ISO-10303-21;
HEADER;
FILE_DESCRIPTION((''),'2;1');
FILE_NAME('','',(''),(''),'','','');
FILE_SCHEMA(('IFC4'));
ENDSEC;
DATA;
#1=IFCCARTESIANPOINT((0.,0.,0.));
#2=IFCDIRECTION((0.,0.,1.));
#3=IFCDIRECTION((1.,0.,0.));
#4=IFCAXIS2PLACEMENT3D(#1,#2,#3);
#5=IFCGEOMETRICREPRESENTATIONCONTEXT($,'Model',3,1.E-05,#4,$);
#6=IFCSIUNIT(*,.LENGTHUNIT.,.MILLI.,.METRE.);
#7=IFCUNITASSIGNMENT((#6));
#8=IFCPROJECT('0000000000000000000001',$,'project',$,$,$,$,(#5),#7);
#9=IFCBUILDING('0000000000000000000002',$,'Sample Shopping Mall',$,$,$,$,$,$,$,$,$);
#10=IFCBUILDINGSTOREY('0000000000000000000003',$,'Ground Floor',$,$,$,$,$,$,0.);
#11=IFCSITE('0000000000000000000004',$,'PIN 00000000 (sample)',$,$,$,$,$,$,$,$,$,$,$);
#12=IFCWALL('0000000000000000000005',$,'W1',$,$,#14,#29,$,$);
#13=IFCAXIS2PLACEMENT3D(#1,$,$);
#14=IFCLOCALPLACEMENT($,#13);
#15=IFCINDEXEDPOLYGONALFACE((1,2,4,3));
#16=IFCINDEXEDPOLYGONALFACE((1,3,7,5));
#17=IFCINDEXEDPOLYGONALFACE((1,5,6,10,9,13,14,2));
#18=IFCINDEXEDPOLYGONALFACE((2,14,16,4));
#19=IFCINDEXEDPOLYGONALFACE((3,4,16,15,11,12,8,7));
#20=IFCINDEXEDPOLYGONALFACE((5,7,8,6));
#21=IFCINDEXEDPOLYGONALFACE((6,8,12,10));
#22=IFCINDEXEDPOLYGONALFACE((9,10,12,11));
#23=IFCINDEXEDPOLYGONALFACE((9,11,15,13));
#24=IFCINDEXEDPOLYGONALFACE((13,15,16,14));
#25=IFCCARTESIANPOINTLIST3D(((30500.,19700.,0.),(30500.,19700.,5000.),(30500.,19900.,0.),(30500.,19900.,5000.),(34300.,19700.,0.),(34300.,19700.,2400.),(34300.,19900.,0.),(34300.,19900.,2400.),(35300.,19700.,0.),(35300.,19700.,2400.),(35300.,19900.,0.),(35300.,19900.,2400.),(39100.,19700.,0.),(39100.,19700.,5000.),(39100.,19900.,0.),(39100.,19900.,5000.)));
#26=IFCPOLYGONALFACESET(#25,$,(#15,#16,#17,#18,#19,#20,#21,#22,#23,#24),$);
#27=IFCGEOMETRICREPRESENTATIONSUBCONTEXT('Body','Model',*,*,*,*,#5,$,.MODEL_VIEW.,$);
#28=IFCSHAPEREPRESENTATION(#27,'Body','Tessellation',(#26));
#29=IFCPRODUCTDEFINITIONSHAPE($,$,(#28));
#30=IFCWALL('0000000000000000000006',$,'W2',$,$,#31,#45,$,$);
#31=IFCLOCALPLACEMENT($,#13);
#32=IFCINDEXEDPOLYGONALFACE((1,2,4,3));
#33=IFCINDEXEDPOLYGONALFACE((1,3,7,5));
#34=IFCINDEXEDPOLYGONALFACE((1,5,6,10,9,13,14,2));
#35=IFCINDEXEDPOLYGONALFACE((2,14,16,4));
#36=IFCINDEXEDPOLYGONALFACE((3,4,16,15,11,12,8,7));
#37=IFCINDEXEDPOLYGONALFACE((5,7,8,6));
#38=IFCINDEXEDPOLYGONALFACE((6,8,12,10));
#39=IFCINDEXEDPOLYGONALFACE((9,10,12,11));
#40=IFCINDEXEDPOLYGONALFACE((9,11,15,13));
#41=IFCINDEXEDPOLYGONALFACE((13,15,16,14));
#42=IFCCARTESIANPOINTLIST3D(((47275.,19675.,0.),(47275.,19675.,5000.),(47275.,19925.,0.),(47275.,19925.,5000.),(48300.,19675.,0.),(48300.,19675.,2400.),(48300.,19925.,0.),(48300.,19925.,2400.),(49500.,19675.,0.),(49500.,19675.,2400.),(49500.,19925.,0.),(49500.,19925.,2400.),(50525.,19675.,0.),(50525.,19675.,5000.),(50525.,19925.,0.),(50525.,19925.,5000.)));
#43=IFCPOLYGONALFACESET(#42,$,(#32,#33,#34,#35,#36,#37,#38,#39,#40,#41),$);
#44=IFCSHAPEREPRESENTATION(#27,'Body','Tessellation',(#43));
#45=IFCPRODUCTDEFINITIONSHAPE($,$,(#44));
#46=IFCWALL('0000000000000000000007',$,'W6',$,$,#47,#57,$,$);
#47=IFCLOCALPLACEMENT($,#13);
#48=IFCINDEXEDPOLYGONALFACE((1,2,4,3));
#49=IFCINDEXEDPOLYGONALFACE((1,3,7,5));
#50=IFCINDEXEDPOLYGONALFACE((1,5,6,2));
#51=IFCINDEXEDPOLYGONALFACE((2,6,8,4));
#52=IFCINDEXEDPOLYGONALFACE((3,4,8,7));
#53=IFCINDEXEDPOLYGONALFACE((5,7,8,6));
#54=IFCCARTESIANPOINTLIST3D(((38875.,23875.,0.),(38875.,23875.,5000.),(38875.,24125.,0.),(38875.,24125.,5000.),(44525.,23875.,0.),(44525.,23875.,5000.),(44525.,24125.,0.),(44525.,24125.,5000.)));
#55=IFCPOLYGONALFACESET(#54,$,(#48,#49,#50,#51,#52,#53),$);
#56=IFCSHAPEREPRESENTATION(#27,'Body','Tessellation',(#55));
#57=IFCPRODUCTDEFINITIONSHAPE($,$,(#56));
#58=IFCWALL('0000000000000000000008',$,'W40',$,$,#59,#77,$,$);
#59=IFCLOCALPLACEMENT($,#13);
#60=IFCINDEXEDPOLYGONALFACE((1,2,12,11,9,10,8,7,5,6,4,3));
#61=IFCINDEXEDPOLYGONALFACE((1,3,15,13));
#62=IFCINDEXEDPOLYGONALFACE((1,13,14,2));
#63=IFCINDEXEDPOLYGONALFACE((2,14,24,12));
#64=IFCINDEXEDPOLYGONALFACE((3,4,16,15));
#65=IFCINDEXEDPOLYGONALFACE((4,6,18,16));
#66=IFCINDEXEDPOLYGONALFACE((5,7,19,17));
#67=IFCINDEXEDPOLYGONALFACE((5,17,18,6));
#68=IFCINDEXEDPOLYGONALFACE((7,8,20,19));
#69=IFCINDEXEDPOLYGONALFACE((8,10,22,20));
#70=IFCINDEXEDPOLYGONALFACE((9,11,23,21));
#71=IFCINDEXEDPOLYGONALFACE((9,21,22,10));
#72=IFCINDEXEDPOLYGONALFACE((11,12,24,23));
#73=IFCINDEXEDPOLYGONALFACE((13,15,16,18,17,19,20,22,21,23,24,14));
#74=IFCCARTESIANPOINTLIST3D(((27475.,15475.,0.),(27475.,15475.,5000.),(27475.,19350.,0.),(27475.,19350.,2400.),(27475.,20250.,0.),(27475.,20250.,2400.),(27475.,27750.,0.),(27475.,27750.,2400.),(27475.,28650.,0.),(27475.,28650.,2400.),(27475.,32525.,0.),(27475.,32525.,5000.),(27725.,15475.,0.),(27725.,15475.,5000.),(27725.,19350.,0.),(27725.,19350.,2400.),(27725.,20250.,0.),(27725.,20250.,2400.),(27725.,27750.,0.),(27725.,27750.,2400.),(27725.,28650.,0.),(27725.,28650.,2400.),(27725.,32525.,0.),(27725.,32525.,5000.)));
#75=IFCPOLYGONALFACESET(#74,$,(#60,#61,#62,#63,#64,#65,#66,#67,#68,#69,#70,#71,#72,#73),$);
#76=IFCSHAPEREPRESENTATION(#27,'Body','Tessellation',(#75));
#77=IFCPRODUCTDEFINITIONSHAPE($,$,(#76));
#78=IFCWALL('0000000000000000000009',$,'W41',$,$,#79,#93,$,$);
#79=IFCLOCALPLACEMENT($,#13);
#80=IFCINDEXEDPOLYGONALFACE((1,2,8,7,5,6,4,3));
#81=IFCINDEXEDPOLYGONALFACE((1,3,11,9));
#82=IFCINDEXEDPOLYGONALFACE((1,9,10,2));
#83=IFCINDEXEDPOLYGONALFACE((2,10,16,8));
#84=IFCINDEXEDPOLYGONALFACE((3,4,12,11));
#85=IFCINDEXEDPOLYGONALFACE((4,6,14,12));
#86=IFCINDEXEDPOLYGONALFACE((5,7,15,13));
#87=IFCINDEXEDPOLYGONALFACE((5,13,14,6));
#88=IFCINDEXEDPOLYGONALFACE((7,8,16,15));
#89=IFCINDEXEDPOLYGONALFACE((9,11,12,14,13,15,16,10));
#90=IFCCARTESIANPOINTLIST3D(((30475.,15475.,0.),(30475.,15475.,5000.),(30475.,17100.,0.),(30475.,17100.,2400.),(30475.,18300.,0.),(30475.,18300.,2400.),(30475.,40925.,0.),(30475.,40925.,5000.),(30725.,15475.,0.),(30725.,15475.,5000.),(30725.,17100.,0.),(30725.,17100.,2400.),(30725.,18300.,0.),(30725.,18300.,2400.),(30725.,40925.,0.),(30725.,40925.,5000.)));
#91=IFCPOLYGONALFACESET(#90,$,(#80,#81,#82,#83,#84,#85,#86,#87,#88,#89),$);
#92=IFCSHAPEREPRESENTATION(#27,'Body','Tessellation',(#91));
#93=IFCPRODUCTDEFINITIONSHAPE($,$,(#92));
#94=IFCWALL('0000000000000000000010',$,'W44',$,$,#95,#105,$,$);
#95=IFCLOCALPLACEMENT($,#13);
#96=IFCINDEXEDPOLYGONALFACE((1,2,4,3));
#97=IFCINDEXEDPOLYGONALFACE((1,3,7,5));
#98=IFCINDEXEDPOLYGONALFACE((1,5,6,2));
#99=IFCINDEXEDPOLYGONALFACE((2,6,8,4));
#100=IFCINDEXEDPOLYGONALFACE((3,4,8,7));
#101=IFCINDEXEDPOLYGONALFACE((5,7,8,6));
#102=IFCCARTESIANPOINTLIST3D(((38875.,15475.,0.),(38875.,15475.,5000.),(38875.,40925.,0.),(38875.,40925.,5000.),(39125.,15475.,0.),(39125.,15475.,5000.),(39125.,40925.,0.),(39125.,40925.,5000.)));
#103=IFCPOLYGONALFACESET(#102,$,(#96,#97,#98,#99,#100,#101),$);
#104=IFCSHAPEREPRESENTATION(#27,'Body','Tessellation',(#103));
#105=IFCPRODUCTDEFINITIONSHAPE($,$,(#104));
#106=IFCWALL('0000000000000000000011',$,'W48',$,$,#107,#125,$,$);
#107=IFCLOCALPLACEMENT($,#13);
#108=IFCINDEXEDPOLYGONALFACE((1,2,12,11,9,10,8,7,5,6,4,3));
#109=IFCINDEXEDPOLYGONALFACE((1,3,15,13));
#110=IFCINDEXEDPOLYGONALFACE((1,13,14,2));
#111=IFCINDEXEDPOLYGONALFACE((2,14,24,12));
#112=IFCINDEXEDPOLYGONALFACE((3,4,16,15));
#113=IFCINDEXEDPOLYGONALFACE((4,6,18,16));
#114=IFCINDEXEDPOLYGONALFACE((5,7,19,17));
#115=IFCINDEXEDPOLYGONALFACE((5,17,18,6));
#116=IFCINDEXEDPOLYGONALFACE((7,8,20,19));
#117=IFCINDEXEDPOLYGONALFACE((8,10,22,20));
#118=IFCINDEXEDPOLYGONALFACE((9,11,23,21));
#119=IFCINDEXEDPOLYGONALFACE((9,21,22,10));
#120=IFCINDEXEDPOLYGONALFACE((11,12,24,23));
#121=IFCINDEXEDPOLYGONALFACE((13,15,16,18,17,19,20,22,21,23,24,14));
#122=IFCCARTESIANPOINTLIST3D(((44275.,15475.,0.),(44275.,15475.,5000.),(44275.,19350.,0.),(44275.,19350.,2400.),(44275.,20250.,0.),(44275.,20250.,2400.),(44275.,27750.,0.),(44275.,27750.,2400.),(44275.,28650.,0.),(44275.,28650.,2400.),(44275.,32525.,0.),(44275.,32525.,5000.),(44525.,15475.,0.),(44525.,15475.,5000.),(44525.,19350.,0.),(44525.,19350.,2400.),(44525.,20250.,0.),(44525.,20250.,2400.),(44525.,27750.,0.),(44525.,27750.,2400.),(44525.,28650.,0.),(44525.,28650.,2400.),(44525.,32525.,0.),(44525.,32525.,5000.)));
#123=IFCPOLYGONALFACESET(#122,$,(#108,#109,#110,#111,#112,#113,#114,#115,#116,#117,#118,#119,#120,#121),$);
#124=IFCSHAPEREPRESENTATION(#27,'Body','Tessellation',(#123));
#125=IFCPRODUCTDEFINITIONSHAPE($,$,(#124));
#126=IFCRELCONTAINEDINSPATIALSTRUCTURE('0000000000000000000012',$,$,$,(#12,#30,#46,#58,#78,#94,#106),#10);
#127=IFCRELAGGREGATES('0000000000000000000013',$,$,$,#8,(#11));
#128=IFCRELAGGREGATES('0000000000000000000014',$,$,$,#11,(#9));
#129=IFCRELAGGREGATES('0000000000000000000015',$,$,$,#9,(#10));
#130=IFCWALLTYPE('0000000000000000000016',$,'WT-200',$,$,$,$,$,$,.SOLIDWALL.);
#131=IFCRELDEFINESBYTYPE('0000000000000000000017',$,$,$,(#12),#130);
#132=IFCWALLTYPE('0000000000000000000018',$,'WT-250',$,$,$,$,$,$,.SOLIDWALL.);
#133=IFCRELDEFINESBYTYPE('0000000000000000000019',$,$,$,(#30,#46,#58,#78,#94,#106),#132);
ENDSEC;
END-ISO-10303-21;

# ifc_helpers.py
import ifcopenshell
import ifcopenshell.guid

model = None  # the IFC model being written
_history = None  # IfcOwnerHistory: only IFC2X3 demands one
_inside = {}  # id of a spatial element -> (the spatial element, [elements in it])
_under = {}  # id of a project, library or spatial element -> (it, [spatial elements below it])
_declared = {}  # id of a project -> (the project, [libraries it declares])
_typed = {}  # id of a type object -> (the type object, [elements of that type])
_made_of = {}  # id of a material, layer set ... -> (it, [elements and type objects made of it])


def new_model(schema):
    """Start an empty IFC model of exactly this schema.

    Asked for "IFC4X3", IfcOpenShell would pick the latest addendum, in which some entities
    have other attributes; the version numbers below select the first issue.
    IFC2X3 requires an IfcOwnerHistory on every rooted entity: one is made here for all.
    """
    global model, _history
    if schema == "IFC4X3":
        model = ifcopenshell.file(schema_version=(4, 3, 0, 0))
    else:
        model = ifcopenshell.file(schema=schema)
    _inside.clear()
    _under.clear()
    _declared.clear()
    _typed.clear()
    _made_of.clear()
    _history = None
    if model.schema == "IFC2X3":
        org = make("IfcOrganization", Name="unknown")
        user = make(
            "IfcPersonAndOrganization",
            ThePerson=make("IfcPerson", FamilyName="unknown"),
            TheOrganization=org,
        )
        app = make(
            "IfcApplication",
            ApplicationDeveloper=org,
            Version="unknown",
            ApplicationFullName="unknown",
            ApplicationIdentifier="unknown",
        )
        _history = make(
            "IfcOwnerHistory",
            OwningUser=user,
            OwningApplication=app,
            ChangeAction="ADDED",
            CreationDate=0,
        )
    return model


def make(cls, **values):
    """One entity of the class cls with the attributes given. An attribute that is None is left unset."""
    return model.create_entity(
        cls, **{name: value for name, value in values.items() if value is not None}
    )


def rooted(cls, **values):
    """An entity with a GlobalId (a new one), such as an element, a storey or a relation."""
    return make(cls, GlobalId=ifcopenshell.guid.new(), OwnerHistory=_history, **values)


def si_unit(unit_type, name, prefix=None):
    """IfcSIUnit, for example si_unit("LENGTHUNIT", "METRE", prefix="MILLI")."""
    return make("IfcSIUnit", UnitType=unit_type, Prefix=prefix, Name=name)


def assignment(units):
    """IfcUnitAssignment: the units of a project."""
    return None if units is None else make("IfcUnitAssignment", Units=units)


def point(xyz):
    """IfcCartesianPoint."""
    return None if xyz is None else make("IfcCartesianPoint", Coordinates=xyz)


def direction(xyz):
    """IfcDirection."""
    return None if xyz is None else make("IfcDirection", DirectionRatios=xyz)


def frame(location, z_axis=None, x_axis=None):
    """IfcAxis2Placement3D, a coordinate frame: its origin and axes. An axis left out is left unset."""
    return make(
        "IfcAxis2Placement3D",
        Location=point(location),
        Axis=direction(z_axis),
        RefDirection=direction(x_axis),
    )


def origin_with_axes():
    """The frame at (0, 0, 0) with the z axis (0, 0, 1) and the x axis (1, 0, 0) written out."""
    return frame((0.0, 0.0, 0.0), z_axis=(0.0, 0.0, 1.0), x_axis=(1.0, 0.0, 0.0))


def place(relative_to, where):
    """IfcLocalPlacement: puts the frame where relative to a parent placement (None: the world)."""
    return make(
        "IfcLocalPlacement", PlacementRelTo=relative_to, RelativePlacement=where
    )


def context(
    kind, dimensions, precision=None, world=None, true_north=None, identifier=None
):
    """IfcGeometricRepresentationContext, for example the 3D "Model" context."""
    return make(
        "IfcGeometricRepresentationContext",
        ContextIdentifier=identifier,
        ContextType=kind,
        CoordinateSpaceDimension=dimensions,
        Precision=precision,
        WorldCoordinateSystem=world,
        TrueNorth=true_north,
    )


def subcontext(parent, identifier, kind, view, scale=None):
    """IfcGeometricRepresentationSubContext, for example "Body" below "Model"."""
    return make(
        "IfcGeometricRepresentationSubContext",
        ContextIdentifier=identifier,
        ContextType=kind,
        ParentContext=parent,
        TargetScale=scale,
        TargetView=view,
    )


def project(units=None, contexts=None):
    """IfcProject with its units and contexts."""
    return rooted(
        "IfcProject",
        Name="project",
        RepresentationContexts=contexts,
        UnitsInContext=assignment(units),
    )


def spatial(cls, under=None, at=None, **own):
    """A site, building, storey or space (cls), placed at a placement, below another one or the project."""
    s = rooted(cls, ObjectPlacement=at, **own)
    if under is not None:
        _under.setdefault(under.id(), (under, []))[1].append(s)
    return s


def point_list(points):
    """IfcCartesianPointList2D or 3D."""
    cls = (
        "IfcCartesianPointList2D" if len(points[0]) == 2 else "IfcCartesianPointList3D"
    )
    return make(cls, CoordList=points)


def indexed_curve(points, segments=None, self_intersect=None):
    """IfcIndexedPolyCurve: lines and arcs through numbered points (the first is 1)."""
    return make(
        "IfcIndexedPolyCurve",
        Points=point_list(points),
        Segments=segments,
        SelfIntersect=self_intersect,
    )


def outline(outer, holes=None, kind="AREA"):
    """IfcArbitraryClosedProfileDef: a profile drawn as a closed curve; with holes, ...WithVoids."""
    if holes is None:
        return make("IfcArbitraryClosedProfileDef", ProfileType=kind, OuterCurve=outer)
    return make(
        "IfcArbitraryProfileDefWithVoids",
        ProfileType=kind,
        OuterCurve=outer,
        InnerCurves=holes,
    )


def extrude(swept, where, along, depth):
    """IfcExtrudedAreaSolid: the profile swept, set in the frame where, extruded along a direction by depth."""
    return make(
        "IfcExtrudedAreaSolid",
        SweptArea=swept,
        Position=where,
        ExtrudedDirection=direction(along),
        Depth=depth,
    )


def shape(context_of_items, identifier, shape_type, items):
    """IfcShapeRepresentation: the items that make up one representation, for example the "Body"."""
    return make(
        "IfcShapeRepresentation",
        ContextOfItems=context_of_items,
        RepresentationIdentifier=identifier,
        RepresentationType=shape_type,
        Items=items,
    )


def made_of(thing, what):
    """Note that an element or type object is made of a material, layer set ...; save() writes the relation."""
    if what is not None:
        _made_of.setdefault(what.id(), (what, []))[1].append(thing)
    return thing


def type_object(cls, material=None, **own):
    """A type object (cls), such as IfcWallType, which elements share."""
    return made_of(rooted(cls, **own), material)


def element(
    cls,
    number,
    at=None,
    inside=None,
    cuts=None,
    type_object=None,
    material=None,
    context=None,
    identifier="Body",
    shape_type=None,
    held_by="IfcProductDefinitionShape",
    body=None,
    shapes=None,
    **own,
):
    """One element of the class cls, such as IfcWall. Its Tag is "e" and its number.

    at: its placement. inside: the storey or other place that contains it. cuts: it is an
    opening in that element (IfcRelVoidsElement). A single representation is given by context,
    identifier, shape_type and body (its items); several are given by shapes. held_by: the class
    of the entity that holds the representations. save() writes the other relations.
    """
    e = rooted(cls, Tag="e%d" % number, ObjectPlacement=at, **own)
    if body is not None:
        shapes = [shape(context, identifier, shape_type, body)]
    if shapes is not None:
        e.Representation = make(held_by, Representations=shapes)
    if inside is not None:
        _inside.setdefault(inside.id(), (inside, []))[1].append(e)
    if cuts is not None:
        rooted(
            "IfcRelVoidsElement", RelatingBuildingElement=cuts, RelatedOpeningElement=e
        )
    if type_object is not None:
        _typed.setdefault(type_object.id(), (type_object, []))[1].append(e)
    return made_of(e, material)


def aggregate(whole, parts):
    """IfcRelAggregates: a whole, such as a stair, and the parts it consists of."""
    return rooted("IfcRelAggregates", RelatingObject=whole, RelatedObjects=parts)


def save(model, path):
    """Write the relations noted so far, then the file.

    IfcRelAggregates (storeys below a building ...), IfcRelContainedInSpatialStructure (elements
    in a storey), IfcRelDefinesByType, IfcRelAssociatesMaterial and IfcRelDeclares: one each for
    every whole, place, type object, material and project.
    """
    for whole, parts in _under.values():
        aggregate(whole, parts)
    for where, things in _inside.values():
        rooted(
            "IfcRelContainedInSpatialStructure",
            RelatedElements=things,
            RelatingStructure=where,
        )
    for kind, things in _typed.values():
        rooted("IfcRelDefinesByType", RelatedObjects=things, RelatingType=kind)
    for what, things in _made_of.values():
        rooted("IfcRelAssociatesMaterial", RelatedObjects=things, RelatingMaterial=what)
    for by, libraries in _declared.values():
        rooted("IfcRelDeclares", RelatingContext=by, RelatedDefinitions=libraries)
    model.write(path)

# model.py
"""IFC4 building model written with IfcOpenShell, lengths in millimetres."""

from ifc_helpers import new_model, si_unit, frame, origin_with_axes, place, context, subcontext, project, spatial, indexed_curve, outline, extrude, type_object, element, save


model = new_model("IFC4")

# Units and contexts
model_context = context("Model", 3, precision=1e-05, world=origin_with_axes())
body_context = subcontext(model_context, "Body", "Model", "MODEL_VIEW")
ifc_project = project(units=[si_unit("LENGTHUNIT", "METRE", prefix="MILLI")], contexts=[model_context])

# Site, building, storey
site = spatial("IfcSite", under=ifc_project, Name="PIN 00000000 (sample)")
building = spatial("IfcBuilding", under=site, Name="Sample Shopping Mall")
storey = spatial("IfcBuildingStorey", under=building, Name="Ground Floor", Elevation=0.0)

# Walls, openings
wall_type_1 = type_object("IfcWallType", Name="WT-200", PredefinedType="SOLIDWALL")
wall_1_placement = place(None, frame((30500.0, 19700.0, 0.0), z_axis=(0.0, 0.0, 1.0), x_axis=(1.0, 0.0, 0.0)))
wall_1 = element("IfcWall", 1, at=wall_1_placement, inside=storey, type_object=wall_type_1, Name="W1", context=body_context, shape_type="SweptSolid", body=[
    extrude(outline(indexed_curve([(0.0, 0.0), (0.0, 200.0), (8600.0, 200.0), (8600.0, 0.0), (0.0, 0.0)], self_intersect=False)), origin_with_axes(), (0.0, 0.0, 1.0), 5000.0),
])
opening_1_placement = place(wall_1_placement, frame((3800.0, -100.0, 0.0), z_axis=(0.0, 0.0, 1.0), x_axis=(1.0, 0.0, 0.0)))
element("IfcOpeningElement", 2, at=opening_1_placement, cuts=wall_1, context=body_context, shape_type="SweptSolid", body=[
    extrude(outline(indexed_curve([(0.0, 0.0), (0.0, 400.0), (1000.0, 400.0), (1000.0, 0.0), (0.0, 0.0)], self_intersect=False)), origin_with_axes(), (0.0, 0.0, 1.0), 2400.0),
])
wall_type_2 = type_object("IfcWallType", Name="WT-250", PredefinedType="SOLIDWALL")
wall_2_placement = place(None, frame((47275.0, 19675.0, 0.0), z_axis=(0.0, 0.0, 1.0), x_axis=(1.0, 0.0, 0.0)))
wall_2 = element("IfcWall", 3, at=wall_2_placement, inside=storey, type_object=wall_type_2, Name="W2", context=body_context, shape_type="SweptSolid", body=[
    extrude(outline(indexed_curve([(0.0, 0.0), (0.0, 250.0), (3250.0, 250.0), (3250.0, 0.0), (0.0, 0.0)], self_intersect=False)), origin_with_axes(), (0.0, 0.0, 1.0), 5000.0),
])
opening_2_placement = place(wall_2_placement, frame((1025.0, -100.0, 0.0), z_axis=(0.0, 0.0, 1.0), x_axis=(1.0, 0.0, 0.0)))
element("IfcOpeningElement", 4, at=opening_2_placement, cuts=wall_2, context=body_context, shape_type="SweptSolid", body=[
    extrude(outline(indexed_curve([(0.0, 0.0), (0.0, 450.0), (1200.0, 450.0), (1200.0, 0.0), (0.0, 0.0)], self_intersect=False)), origin_with_axes(), (0.0, 0.0, 1.0), 2400.0),
])

# Wall
wall_3_placement = place(None, frame((38875.0, 23875.0, 0.0), z_axis=(0.0, 0.0, 1.0), x_axis=(1.0, 0.0, 0.0)))
element("IfcWall", 5, at=wall_3_placement, inside=storey, type_object=wall_type_2, Name="W6", context=body_context, shape_type="SweptSolid", body=[
    extrude(outline(indexed_curve([(0.0, 0.0), (0.0, 250.0), (5650.0, 250.0), (5650.0, 0.0), (0.0, 0.0)], self_intersect=False)), origin_with_axes(), (0.0, 0.0, 1.0), 5000.0),
])

# Wall, openings
wall_4_placement = place(None, frame((27725.0, 15475.0, 0.0), z_axis=(0.0, 0.0, 1.0), x_axis=(0.0, 1.0, 0.0)))
wall_4 = element("IfcWall", 6, at=wall_4_placement, inside=storey, type_object=wall_type_2, Name="W40", context=body_context, shape_type="SweptSolid", body=[
    extrude(outline(indexed_curve([(0.0, 0.0), (0.0, 250.0), (17050.0, 250.0), (17050.0, 0.0), (0.0, 0.0)], self_intersect=False)), origin_with_axes(), (0.0, 0.0, 1.0), 5000.0),
])
opening_3_placement = place(wall_4_placement, frame((12275.0, -100.0, 0.0), z_axis=(0.0, 0.0, 1.0), x_axis=(1.0, 0.0, 0.0)))
element("IfcOpeningElement", 7, at=opening_3_placement, cuts=wall_4, context=body_context, shape_type="SweptSolid", body=[
    extrude(outline(indexed_curve([(0.0, 0.0), (0.0, 450.0), (900.0, 450.0), (900.0, 0.0), (0.0, 0.0)], self_intersect=False)), origin_with_axes(), (0.0, 0.0, 1.0), 2400.0),
])
opening_4_placement = place(wall_4_placement, frame((3875.0, -100.0, 0.0), z_axis=(0.0, 0.0, 1.0), x_axis=(1.0, 0.0, 0.0)))
element("IfcOpeningElement", 8, at=opening_4_placement, cuts=wall_4, context=body_context, shape_type="SweptSolid", body=[
    extrude(outline(indexed_curve([(0.0, 0.0), (0.0, 450.0), (900.0, 450.0), (900.0, 0.0), (0.0, 0.0)], self_intersect=False)), origin_with_axes(), (0.0, 0.0, 1.0), 2400.0),
])

# Wall, opening
wall_5_placement = place(None, frame((30725.0, 15475.0, 0.0), z_axis=(0.0, 0.0, 1.0), x_axis=(0.0, 1.0, 0.0)))
wall_5 = element("IfcWall", 9, at=wall_5_placement, inside=storey, type_object=wall_type_2, Name="W41", context=body_context, shape_type="SweptSolid", body=[
    extrude(outline(indexed_curve([(0.0, 0.0), (0.0, 250.0), (25450.0, 250.0), (25450.0, 0.0), (0.0, 0.0)], self_intersect=False)), origin_with_axes(), (0.0, 0.0, 1.0), 5000.0),
])
opening_5_placement = place(wall_5_placement, frame((1625.0, -100.0, 0.0), z_axis=(0.0, 0.0, 1.0), x_axis=(1.0, 0.0, 0.0)))
element("IfcOpeningElement", 10, at=opening_5_placement, cuts=wall_5, context=body_context, shape_type="SweptSolid", body=[
    extrude(outline(indexed_curve([(0.0, 0.0), (0.0, 450.0), (1200.0, 450.0), (1200.0, 0.0), (0.0, 0.0)], self_intersect=False)), origin_with_axes(), (0.0, 0.0, 1.0), 2400.0),
])

# Wall
wall_6_placement = place(None, frame((39125.0, 15475.0, 0.0), z_axis=(0.0, 0.0, 1.0), x_axis=(0.0, 1.0, 0.0)))
element("IfcWall", 11, at=wall_6_placement, inside=storey, type_object=wall_type_2, Name="W44", context=body_context, shape_type="SweptSolid", body=[
    extrude(outline(indexed_curve([(0.0, 0.0), (0.0, 250.0), (25450.0, 250.0), (25450.0, 0.0), (0.0, 0.0)], self_intersect=False)), origin_with_axes(), (0.0, 0.0, 1.0), 5000.0),
])

# Wall, openings
wall_7_placement = place(None, frame((44525.0, 15475.0, 0.0), z_axis=(0.0, 0.0, 1.0), x_axis=(0.0, 1.0, 0.0)))
wall_7 = element("IfcWall", 12, at=wall_7_placement, inside=storey, type_object=wall_type_2, Name="W48", context=body_context, shape_type="SweptSolid", body=[
    extrude(outline(indexed_curve([(0.0, 0.0), (0.0, 250.0), (17050.0, 250.0), (17050.0, 0.0), (0.0, 0.0)], self_intersect=False)), origin_with_axes(), (0.0, 0.0, 1.0), 5000.0),
])
opening_6_placement = place(wall_7_placement, frame((12275.0, -100.0, 0.0), z_axis=(0.0, 0.0, 1.0), x_axis=(1.0, 0.0, 0.0)))
element("IfcOpeningElement", 13, at=opening_6_placement, cuts=wall_7, context=body_context, shape_type="SweptSolid", body=[
    extrude(outline(indexed_curve([(0.0, 0.0), (0.0, 450.0), (900.0, 450.0), (900.0, 0.0), (0.0, 0.0)], self_intersect=False)), origin_with_axes(), (0.0, 0.0, 1.0), 2400.0),
])
opening_7_placement = place(wall_7_placement, frame((3875.0, -100.0, 0.0), z_axis=(0.0, 0.0, 1.0), x_axis=(1.0, 0.0, 0.0)))
element("IfcOpeningElement", 14, at=opening_7_placement, cuts=wall_7, context=body_context, shape_type="SweptSolid", body=[
    extrude(outline(indexed_curve([(0.0, 0.0), (0.0, 450.0), (900.0, 450.0), (900.0, 0.0), (0.0, 0.0)], self_intersect=False)), origin_with_axes(), (0.0, 0.0, 1.0), 2400.0),
])

save(model, "model.ifc")
